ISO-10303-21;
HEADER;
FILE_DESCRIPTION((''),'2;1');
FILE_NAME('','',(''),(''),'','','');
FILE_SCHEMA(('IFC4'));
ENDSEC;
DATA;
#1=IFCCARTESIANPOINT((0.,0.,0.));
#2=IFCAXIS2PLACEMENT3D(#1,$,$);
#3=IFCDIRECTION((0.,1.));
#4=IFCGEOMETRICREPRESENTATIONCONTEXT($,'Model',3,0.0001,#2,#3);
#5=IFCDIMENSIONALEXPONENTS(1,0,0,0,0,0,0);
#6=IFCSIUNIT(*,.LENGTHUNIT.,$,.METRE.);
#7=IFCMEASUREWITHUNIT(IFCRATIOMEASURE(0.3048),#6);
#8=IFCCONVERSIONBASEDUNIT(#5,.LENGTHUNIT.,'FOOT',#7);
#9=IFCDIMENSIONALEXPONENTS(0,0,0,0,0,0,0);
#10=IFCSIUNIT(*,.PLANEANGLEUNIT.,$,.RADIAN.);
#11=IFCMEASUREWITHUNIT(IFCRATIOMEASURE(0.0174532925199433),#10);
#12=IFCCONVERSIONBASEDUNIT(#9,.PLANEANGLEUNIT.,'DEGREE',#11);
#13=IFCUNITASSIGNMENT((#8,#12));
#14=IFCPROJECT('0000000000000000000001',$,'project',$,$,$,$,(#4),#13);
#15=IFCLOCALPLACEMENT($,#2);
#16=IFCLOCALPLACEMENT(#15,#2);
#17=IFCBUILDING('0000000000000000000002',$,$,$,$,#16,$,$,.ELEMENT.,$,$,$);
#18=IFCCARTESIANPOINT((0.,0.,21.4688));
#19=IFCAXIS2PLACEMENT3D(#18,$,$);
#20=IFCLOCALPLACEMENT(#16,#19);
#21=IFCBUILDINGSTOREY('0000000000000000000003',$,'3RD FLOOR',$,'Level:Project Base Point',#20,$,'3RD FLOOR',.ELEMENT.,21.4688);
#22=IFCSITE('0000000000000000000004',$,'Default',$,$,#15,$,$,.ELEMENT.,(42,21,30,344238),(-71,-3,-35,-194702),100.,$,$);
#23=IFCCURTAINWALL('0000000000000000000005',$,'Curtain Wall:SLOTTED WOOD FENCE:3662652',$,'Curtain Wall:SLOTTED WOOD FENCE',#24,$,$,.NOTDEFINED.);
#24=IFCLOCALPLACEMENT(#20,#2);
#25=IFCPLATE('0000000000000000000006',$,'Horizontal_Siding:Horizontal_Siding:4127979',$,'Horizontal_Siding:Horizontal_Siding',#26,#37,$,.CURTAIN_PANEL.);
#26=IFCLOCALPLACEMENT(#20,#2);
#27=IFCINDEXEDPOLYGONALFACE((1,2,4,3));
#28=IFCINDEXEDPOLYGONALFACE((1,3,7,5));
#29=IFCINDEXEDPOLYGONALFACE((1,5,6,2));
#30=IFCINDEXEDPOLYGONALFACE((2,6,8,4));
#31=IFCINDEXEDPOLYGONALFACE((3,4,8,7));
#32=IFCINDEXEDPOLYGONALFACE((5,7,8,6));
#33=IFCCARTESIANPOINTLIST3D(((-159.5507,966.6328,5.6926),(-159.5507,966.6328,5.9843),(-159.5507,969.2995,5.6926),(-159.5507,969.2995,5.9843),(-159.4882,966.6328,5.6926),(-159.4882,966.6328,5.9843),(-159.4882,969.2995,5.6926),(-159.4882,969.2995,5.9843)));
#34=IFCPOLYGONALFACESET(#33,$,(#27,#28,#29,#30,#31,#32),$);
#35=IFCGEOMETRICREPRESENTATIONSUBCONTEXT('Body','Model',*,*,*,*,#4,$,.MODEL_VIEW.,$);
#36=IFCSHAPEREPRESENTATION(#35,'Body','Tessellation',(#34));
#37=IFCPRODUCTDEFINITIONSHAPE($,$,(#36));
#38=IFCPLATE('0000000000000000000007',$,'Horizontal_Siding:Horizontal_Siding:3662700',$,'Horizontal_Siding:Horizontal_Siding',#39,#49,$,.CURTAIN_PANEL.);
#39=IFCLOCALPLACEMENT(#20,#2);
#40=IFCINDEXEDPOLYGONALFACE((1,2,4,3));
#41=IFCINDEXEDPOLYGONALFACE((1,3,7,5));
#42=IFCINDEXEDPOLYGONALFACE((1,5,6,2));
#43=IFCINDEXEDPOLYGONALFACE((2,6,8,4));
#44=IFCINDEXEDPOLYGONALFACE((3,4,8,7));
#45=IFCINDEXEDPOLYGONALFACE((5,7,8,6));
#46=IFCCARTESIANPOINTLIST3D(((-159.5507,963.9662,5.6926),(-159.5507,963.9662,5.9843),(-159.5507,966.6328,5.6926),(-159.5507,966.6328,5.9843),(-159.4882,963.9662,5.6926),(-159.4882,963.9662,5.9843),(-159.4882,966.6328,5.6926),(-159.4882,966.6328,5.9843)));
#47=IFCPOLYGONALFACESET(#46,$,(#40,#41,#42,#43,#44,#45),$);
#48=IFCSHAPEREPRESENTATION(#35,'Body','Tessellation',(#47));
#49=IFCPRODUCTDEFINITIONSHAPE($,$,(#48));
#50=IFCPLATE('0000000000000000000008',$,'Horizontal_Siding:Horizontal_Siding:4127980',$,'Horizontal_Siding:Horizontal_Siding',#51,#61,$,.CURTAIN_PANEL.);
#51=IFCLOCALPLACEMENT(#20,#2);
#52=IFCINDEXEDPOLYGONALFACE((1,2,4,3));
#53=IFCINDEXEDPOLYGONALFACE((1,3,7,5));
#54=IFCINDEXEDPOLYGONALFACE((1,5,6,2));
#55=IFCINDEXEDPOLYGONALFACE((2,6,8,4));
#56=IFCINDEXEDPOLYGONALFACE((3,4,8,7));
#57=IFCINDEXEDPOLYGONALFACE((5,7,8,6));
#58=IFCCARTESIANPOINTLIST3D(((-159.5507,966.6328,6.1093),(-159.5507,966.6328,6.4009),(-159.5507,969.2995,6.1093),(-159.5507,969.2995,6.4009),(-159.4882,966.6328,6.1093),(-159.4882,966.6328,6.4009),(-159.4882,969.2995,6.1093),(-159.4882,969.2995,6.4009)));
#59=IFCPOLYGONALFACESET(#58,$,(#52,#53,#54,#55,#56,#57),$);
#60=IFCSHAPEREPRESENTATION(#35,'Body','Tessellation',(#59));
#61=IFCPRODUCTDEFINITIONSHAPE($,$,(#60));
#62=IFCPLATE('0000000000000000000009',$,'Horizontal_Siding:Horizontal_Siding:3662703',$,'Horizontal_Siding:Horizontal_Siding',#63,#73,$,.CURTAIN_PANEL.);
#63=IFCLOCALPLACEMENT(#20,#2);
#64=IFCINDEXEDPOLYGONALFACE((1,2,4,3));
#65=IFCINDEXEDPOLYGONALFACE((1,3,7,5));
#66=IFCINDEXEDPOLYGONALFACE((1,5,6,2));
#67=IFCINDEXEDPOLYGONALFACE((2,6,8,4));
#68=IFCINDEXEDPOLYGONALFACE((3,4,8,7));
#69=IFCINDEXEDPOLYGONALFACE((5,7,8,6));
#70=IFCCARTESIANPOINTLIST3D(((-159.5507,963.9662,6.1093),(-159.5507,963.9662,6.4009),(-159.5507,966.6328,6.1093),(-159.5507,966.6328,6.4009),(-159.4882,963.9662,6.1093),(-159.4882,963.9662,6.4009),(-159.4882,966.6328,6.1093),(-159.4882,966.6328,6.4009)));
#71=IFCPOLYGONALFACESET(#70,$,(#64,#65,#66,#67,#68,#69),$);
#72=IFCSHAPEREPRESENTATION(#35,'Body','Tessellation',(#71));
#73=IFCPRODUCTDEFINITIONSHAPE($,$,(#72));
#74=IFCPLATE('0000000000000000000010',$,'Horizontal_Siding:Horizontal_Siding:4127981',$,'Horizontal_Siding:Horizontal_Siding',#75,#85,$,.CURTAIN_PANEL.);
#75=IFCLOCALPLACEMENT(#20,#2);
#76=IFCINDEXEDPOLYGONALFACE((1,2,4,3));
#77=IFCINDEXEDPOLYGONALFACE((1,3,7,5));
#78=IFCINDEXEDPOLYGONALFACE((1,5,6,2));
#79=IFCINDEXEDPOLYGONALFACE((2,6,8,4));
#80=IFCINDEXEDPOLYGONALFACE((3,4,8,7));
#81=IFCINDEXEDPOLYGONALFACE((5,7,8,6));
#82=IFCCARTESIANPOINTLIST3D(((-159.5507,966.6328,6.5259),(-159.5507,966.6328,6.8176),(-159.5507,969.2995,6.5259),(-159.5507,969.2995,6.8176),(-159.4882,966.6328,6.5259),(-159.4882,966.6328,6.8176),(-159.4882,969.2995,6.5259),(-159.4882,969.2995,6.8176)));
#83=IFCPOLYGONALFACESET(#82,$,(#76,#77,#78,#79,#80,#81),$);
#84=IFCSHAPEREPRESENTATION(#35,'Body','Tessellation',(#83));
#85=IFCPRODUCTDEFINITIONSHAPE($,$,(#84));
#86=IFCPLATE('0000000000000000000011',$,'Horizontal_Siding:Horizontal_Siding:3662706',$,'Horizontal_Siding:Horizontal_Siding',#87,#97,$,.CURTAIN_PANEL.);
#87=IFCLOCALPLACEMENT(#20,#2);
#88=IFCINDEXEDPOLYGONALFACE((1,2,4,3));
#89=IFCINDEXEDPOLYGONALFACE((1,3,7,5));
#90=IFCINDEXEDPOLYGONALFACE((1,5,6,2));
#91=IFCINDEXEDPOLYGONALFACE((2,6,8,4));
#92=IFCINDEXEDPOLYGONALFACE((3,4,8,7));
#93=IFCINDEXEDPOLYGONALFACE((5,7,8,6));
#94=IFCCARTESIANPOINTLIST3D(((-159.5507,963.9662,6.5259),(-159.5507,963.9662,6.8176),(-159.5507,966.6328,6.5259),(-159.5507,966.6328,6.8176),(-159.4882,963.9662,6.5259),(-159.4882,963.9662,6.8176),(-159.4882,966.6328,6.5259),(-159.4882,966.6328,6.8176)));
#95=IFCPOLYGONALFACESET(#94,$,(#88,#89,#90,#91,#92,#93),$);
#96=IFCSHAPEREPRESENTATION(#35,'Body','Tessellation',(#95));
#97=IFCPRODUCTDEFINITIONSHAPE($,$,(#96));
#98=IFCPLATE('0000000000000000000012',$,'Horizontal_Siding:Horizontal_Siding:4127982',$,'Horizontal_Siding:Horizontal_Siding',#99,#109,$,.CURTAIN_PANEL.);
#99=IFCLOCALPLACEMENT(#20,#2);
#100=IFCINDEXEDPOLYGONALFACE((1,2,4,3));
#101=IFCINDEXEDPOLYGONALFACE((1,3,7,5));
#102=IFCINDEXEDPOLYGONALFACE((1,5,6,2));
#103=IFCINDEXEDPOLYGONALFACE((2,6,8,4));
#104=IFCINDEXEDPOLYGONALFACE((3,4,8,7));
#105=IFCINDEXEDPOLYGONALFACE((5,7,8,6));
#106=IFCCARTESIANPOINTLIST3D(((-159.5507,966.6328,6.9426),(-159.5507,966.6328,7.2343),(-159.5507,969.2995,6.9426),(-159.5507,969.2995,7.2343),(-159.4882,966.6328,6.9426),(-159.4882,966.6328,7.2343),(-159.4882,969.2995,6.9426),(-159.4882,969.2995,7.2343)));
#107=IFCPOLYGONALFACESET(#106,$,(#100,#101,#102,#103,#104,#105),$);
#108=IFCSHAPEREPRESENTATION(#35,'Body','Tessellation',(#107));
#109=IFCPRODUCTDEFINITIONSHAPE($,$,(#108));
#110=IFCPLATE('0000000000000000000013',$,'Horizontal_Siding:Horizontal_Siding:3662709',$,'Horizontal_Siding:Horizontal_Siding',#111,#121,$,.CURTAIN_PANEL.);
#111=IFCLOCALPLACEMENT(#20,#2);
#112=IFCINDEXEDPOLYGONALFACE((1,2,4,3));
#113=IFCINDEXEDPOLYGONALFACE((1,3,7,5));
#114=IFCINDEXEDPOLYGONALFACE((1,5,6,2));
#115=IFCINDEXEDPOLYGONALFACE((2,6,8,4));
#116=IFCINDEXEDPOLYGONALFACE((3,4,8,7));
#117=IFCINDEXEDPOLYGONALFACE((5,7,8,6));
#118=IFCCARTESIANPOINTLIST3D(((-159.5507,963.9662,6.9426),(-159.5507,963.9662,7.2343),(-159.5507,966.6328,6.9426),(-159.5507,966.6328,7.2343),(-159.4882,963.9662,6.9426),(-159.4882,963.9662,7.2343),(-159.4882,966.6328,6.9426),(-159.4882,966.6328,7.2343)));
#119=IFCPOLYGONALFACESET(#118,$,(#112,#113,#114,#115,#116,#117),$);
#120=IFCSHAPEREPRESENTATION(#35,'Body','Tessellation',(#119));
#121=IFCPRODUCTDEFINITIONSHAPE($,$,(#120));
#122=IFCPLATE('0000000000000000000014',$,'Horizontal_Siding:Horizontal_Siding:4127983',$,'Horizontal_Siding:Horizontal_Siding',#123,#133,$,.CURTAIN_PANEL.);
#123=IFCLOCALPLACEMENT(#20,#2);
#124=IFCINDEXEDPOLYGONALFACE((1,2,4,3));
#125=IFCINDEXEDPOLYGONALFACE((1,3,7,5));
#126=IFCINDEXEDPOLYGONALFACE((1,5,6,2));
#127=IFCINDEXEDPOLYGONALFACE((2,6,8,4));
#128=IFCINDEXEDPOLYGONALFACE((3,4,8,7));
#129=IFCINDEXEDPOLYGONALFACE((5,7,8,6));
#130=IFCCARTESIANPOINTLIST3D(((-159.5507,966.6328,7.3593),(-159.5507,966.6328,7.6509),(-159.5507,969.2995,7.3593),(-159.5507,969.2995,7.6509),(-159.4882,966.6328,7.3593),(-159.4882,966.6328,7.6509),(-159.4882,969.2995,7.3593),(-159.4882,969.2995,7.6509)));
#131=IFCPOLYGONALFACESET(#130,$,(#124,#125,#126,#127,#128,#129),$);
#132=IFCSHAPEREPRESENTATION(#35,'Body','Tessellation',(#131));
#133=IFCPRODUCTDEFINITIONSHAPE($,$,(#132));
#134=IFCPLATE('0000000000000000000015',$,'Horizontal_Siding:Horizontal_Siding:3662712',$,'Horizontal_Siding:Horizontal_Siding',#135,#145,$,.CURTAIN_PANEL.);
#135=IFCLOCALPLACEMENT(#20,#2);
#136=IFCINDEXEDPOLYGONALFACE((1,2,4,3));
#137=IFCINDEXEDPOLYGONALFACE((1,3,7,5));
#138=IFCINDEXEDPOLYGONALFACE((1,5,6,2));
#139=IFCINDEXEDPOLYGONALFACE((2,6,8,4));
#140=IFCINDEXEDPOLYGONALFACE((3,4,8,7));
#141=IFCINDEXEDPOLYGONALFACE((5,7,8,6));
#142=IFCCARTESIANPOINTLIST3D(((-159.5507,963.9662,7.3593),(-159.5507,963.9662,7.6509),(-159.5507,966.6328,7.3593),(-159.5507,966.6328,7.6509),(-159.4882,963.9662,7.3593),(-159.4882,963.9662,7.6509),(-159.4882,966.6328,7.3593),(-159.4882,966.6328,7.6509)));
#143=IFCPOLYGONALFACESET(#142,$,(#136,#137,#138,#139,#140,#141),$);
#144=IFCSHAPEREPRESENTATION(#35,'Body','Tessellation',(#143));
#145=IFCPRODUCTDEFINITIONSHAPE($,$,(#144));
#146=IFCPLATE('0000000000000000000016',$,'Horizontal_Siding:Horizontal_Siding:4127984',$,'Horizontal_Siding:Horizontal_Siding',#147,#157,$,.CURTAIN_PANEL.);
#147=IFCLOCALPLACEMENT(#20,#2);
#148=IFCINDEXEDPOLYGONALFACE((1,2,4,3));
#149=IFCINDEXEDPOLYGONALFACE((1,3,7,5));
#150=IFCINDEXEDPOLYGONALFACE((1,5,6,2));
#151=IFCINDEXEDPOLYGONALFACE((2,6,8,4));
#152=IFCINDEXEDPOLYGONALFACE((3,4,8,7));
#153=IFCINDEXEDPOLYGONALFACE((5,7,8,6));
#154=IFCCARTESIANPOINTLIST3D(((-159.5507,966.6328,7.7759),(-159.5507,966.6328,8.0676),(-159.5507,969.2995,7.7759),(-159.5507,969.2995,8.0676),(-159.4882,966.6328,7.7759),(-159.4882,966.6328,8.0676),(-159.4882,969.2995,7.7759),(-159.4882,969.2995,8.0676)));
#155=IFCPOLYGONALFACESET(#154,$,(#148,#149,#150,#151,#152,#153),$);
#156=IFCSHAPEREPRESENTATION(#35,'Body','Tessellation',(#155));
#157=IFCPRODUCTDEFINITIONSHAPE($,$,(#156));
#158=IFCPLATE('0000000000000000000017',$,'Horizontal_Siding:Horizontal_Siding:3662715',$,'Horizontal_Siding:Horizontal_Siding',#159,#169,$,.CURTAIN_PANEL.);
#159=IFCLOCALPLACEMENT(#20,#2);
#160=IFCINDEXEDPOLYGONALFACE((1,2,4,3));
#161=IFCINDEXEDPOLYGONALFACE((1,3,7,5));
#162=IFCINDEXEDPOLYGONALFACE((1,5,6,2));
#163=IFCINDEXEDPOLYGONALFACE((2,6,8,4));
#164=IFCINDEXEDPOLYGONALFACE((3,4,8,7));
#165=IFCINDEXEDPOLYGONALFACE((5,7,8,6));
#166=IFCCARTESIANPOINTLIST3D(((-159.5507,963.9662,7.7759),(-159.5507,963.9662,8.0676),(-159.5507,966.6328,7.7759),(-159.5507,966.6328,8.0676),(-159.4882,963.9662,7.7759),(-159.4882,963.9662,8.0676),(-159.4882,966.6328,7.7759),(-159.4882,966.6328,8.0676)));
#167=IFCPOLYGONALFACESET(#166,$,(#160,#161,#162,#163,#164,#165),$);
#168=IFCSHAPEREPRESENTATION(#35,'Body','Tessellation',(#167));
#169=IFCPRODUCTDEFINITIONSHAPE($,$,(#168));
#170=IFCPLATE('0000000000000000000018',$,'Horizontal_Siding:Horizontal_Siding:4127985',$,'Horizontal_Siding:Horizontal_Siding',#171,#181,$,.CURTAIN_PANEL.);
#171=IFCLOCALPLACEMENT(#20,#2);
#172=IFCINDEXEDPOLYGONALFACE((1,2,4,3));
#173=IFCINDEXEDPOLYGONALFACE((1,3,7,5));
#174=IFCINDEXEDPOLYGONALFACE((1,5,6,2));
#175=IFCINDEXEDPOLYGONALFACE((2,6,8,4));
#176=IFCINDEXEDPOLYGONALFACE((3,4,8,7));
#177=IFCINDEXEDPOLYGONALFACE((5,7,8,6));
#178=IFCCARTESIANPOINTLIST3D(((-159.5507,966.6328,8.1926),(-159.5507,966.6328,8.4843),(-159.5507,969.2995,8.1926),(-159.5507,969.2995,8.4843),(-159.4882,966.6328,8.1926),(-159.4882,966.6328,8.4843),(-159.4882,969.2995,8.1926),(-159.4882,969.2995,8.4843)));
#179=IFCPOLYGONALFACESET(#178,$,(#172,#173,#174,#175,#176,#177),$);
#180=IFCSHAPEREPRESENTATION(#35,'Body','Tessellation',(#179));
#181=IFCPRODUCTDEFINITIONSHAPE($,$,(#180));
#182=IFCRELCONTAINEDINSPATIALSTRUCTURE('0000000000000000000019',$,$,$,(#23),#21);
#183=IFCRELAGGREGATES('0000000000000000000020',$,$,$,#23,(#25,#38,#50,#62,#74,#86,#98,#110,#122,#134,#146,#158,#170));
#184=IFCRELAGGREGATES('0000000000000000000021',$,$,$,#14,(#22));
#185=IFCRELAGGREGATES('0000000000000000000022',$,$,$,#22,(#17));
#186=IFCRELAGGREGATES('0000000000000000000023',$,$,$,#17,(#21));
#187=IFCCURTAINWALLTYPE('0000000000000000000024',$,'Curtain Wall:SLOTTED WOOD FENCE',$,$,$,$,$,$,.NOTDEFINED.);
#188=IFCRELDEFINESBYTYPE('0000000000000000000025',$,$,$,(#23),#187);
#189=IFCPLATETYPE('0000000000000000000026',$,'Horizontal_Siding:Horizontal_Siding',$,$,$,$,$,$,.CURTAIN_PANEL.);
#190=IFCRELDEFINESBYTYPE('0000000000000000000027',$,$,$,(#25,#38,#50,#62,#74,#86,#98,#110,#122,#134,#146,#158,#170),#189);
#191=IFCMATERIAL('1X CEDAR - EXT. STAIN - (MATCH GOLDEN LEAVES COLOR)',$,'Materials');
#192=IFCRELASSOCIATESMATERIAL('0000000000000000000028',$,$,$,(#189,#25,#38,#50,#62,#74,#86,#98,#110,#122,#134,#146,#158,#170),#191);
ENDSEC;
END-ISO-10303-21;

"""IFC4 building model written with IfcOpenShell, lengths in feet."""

from ifc_helpers import new_model, entity, si_unit, converted_unit, direction, frame, origin, origin_2d_with_axis, place, context, subcontext, project, spatial, rectangle, extrude, source, transform, mapped, material, type_object, type_shapes, element, aggregate, save


model = new_model("IFC4")

# Units and contexts
model_context = context("Model", 3, precision=0.0001, world=origin(), true_north=direction((0.0, 1.0)))
body_context = subcontext(model_context, "Body", "Model", "MODEL_VIEW")
ifc_project = project(units=[converted_unit("LENGTHUNIT", "FOOT", entity("IfcRatioMeasure", 0.3048), si_unit("LENGTHUNIT", "METRE"), dimensions=[1, 0, 0, 0, 0, 0, 0]), converted_unit("PLANEANGLEUNIT", "DEGREE", entity("IfcRatioMeasure", 0.0174532925199433), si_unit("PLANEANGLEUNIT", "RADIAN"), dimensions=[0, 0, 0, 0, 0, 0, 0])], contexts=[model_context])

# Site, building, storey
site_placement = place(None, origin())
site = spatial("IfcSite", under=ifc_project, at=site_placement, Name="Default", CompositionType="ELEMENT", RefLatitude=(42, 21, 30, 344238), RefLongitude=(-71, -3, -35, -194702), RefElevation=100.0)
building_placement = place(site_placement, origin())
building = spatial("IfcBuilding", under=site, at=building_placement, CompositionType="ELEMENT")
storey_placement = place(building_placement, frame((0.0, 0.0, 21.4688)))
storey = spatial("IfcBuildingStorey", under=building, at=storey_placement, Name="3RD FLOOR", ObjectType="Level:Project Base Point", LongName="3RD FLOOR", CompositionType="ELEMENT", Elevation=21.4688)

# Curtain wall, plates
curtain_wall_type = type_object("IfcCurtainWallType", Name="Curtain Wall:SLOTTED WOOD FENCE", PredefinedType="NOTDEFINED")
curtain_wall_placement = place(storey_placement, frame((0.0, 0.0, -21.4688)))
curtain_wall = element("IfcCurtainWall", 1, at=curtain_wall_placement, inside=storey, type_object=curtain_wall_type, Name="Curtain Wall:SLOTTED WOOD FENCE:3662652", ObjectType="Curtain Wall:SLOTTED WOOD FENCE", PredefinedType="NOTDEFINED")
ifc_material_1 = material(Name="1X CEDAR - EXT. STAIN - (MATCH GOLDEN LEAVES COLOR)", Category="Materials")
plate_type_1 = type_object("IfcPlateType", Name="Horizontal_Siding:Horizontal_Siding", PredefinedType="CURTAIN_PANEL", material=ifc_material_1)
shared_shape_1 = source(origin(), body_context, "Body", "SweptSolid", [
    extrude(rectangle(XDim=2.6667, YDim=0.0625, at=origin_2d_with_axis()), frame((1.3333, 0.0312, 0.0), z_axis=(0.0, 0.0, 1.0), x_axis=(-1.0, 0.0, 0.0)), (0.0, 0.0, 1.0), 0.2917),
])
type_shapes(plate_type_1, [shared_shape_1])
plate_1_placement = place(curtain_wall_placement, frame((-159.5507, 969.2995, 27.1613), z_axis=(0.0, 0.0, 1.0), x_axis=(0.0, -1.0, 0.0)))
plate_1 = element("IfcPlate", 2, at=plate_1_placement, type_object=plate_type_1, material=ifc_material_1, Name="Horizontal_Siding:Horizontal_Siding:4127979", ObjectType="Horizontal_Siding:Horizontal_Siding", PredefinedType="CURTAIN_PANEL", context=body_context, shape_type="MappedRepresentation", body=[
    mapped(shared_shape_1, transform((0.0, 0.0, 0.0), scale=1.0)),
])
plate_2_placement = place(curtain_wall_placement, frame((-159.5507, 966.6328, 27.1613), z_axis=(0.0, 0.0, 1.0), x_axis=(0.0, -1.0, 0.0)))
plate_2 = element("IfcPlate", 3, at=plate_2_placement, type_object=plate_type_1, material=ifc_material_1, Name="Horizontal_Siding:Horizontal_Siding:3662700", ObjectType="Horizontal_Siding:Horizontal_Siding", PredefinedType="CURTAIN_PANEL", context=body_context, shape_type="MappedRepresentation", body=[
    mapped(shared_shape_1, transform((0.0, 0.0, 0.0), scale=1.0)),
])
plate_3_placement = place(curtain_wall_placement, frame((-159.5507, 969.2995, 27.578), z_axis=(0.0, 0.0, 1.0), x_axis=(0.0, -1.0, 0.0)))
plate_3 = element("IfcPlate", 4, at=plate_3_placement, type_object=plate_type_1, material=ifc_material_1, Name="Horizontal_Siding:Horizontal_Siding:4127980", ObjectType="Horizontal_Siding:Horizontal_Siding", PredefinedType="CURTAIN_PANEL", context=body_context, shape_type="MappedRepresentation", body=[
    mapped(shared_shape_1, transform((0.0, 0.0, 0.0), scale=1.0)),
])
plate_4_placement = place(curtain_wall_placement, frame((-159.5507, 966.6328, 27.578), z_axis=(0.0, 0.0, 1.0), x_axis=(0.0, -1.0, 0.0)))
plate_4 = element("IfcPlate", 5, at=plate_4_placement, type_object=plate_type_1, material=ifc_material_1, Name="Horizontal_Siding:Horizontal_Siding:3662703", ObjectType="Horizontal_Siding:Horizontal_Siding", PredefinedType="CURTAIN_PANEL", context=body_context, shape_type="MappedRepresentation", body=[
    mapped(shared_shape_1, transform((0.0, 0.0, 0.0), scale=1.0)),
])
plate_5_placement = place(curtain_wall_placement, frame((-159.5507, 969.2995, 27.9947), z_axis=(0.0, 0.0, 1.0), x_axis=(0.0, -1.0, 0.0)))
plate_5 = element("IfcPlate", 6, at=plate_5_placement, type_object=plate_type_1, material=ifc_material_1, Name="Horizontal_Siding:Horizontal_Siding:4127981", ObjectType="Horizontal_Siding:Horizontal_Siding", PredefinedType="CURTAIN_PANEL", context=body_context, shape_type="MappedRepresentation", body=[
    mapped(shared_shape_1, transform((0.0, 0.0, 0.0), scale=1.0)),
])
plate_6_placement = place(curtain_wall_placement, frame((-159.5507, 966.6328, 27.9947), z_axis=(0.0, 0.0, 1.0), x_axis=(0.0, -1.0, 0.0)))
plate_6 = element("IfcPlate", 7, at=plate_6_placement, type_object=plate_type_1, material=ifc_material_1, Name="Horizontal_Siding:Horizontal_Siding:3662706", ObjectType="Horizontal_Siding:Horizontal_Siding", PredefinedType="CURTAIN_PANEL", context=body_context, shape_type="MappedRepresentation", body=[
    mapped(shared_shape_1, transform((0.0, 0.0, 0.0), scale=1.0)),
])
plate_7_placement = place(curtain_wall_placement, frame((-159.5507, 969.2995, 28.4113), z_axis=(0.0, 0.0, 1.0), x_axis=(0.0, -1.0, 0.0)))
plate_7 = element("IfcPlate", 8, at=plate_7_placement, type_object=plate_type_1, material=ifc_material_1, Name="Horizontal_Siding:Horizontal_Siding:4127982", ObjectType="Horizontal_Siding:Horizontal_Siding", PredefinedType="CURTAIN_PANEL", context=body_context, shape_type="MappedRepresentation", body=[
    mapped(shared_shape_1, transform((0.0, 0.0, 0.0), scale=1.0)),
])
plate_8_placement = place(curtain_wall_placement, frame((-159.5507, 966.6328, 28.4113), z_axis=(0.0, 0.0, 1.0), x_axis=(0.0, -1.0, 0.0)))
plate_8 = element("IfcPlate", 9, at=plate_8_placement, type_object=plate_type_1, material=ifc_material_1, Name="Horizontal_Siding:Horizontal_Siding:3662709", ObjectType="Horizontal_Siding:Horizontal_Siding", PredefinedType="CURTAIN_PANEL", context=body_context, shape_type="MappedRepresentation", body=[
    mapped(shared_shape_1, transform((0.0, 0.0, 0.0), scale=1.0)),
])
plate_9_placement = place(curtain_wall_placement, frame((-159.5507, 969.2995, 28.828), z_axis=(0.0, 0.0, 1.0), x_axis=(0.0, -1.0, 0.0)))
plate_9 = element("IfcPlate", 10, at=plate_9_placement, type_object=plate_type_1, material=ifc_material_1, Name="Horizontal_Siding:Horizontal_Siding:4127983", ObjectType="Horizontal_Siding:Horizontal_Siding", PredefinedType="CURTAIN_PANEL", context=body_context, shape_type="MappedRepresentation", body=[
    mapped(shared_shape_1, transform((0.0, 0.0, 0.0), scale=1.0)),
])
plate_10_placement = place(curtain_wall_placement, frame((-159.5507, 966.6328, 28.828), z_axis=(0.0, 0.0, 1.0), x_axis=(0.0, -1.0, 0.0)))
plate_10 = element("IfcPlate", 11, at=plate_10_placement, type_object=plate_type_1, material=ifc_material_1, Name="Horizontal_Siding:Horizontal_Siding:3662712", ObjectType="Horizontal_Siding:Horizontal_Siding", PredefinedType="CURTAIN_PANEL", context=body_context, shape_type="MappedRepresentation", body=[
    mapped(shared_shape_1, transform((0.0, 0.0, 0.0), scale=1.0)),
])
plate_11_placement = place(curtain_wall_placement, frame((-159.5507, 969.2995, 29.2447), z_axis=(0.0, 0.0, 1.0), x_axis=(0.0, -1.0, 0.0)))
plate_11 = element("IfcPlate", 12, at=plate_11_placement, type_object=plate_type_1, material=ifc_material_1, Name="Horizontal_Siding:Horizontal_Siding:4127984", ObjectType="Horizontal_Siding:Horizontal_Siding", PredefinedType="CURTAIN_PANEL", context=body_context, shape_type="MappedRepresentation", body=[
    mapped(shared_shape_1, transform((0.0, 0.0, 0.0), scale=1.0)),
])
plate_12_placement = place(curtain_wall_placement, frame((-159.5507, 966.6328, 29.2447), z_axis=(0.0, 0.0, 1.0), x_axis=(0.0, -1.0, 0.0)))
plate_12 = element("IfcPlate", 13, at=plate_12_placement, type_object=plate_type_1, material=ifc_material_1, Name="Horizontal_Siding:Horizontal_Siding:3662715", ObjectType="Horizontal_Siding:Horizontal_Siding", PredefinedType="CURTAIN_PANEL", context=body_context, shape_type="MappedRepresentation", body=[
    mapped(shared_shape_1, transform((0.0, 0.0, 0.0), scale=1.0)),
])
plate_13_placement = place(curtain_wall_placement, frame((-159.5507, 969.2995, 29.6613), z_axis=(0.0, 0.0, 1.0), x_axis=(0.0, -1.0, 0.0)))
plate_13 = element("IfcPlate", 14, at=plate_13_placement, type_object=plate_type_1, material=ifc_material_1, Name="Horizontal_Siding:Horizontal_Siding:4127985", ObjectType="Horizontal_Siding:Horizontal_Siding", PredefinedType="CURTAIN_PANEL", context=body_context, shape_type="MappedRepresentation", body=[
    mapped(shared_shape_1, transform((0.0, 0.0, 0.0), scale=1.0)),
])
aggregate(curtain_wall, [plate_1, plate_2, plate_3, plate_4, plate_5, plate_6, plate_7, plate_8, plate_9, plate_10, plate_11, plate_12, plate_13])

save(model, "model.ifc")
